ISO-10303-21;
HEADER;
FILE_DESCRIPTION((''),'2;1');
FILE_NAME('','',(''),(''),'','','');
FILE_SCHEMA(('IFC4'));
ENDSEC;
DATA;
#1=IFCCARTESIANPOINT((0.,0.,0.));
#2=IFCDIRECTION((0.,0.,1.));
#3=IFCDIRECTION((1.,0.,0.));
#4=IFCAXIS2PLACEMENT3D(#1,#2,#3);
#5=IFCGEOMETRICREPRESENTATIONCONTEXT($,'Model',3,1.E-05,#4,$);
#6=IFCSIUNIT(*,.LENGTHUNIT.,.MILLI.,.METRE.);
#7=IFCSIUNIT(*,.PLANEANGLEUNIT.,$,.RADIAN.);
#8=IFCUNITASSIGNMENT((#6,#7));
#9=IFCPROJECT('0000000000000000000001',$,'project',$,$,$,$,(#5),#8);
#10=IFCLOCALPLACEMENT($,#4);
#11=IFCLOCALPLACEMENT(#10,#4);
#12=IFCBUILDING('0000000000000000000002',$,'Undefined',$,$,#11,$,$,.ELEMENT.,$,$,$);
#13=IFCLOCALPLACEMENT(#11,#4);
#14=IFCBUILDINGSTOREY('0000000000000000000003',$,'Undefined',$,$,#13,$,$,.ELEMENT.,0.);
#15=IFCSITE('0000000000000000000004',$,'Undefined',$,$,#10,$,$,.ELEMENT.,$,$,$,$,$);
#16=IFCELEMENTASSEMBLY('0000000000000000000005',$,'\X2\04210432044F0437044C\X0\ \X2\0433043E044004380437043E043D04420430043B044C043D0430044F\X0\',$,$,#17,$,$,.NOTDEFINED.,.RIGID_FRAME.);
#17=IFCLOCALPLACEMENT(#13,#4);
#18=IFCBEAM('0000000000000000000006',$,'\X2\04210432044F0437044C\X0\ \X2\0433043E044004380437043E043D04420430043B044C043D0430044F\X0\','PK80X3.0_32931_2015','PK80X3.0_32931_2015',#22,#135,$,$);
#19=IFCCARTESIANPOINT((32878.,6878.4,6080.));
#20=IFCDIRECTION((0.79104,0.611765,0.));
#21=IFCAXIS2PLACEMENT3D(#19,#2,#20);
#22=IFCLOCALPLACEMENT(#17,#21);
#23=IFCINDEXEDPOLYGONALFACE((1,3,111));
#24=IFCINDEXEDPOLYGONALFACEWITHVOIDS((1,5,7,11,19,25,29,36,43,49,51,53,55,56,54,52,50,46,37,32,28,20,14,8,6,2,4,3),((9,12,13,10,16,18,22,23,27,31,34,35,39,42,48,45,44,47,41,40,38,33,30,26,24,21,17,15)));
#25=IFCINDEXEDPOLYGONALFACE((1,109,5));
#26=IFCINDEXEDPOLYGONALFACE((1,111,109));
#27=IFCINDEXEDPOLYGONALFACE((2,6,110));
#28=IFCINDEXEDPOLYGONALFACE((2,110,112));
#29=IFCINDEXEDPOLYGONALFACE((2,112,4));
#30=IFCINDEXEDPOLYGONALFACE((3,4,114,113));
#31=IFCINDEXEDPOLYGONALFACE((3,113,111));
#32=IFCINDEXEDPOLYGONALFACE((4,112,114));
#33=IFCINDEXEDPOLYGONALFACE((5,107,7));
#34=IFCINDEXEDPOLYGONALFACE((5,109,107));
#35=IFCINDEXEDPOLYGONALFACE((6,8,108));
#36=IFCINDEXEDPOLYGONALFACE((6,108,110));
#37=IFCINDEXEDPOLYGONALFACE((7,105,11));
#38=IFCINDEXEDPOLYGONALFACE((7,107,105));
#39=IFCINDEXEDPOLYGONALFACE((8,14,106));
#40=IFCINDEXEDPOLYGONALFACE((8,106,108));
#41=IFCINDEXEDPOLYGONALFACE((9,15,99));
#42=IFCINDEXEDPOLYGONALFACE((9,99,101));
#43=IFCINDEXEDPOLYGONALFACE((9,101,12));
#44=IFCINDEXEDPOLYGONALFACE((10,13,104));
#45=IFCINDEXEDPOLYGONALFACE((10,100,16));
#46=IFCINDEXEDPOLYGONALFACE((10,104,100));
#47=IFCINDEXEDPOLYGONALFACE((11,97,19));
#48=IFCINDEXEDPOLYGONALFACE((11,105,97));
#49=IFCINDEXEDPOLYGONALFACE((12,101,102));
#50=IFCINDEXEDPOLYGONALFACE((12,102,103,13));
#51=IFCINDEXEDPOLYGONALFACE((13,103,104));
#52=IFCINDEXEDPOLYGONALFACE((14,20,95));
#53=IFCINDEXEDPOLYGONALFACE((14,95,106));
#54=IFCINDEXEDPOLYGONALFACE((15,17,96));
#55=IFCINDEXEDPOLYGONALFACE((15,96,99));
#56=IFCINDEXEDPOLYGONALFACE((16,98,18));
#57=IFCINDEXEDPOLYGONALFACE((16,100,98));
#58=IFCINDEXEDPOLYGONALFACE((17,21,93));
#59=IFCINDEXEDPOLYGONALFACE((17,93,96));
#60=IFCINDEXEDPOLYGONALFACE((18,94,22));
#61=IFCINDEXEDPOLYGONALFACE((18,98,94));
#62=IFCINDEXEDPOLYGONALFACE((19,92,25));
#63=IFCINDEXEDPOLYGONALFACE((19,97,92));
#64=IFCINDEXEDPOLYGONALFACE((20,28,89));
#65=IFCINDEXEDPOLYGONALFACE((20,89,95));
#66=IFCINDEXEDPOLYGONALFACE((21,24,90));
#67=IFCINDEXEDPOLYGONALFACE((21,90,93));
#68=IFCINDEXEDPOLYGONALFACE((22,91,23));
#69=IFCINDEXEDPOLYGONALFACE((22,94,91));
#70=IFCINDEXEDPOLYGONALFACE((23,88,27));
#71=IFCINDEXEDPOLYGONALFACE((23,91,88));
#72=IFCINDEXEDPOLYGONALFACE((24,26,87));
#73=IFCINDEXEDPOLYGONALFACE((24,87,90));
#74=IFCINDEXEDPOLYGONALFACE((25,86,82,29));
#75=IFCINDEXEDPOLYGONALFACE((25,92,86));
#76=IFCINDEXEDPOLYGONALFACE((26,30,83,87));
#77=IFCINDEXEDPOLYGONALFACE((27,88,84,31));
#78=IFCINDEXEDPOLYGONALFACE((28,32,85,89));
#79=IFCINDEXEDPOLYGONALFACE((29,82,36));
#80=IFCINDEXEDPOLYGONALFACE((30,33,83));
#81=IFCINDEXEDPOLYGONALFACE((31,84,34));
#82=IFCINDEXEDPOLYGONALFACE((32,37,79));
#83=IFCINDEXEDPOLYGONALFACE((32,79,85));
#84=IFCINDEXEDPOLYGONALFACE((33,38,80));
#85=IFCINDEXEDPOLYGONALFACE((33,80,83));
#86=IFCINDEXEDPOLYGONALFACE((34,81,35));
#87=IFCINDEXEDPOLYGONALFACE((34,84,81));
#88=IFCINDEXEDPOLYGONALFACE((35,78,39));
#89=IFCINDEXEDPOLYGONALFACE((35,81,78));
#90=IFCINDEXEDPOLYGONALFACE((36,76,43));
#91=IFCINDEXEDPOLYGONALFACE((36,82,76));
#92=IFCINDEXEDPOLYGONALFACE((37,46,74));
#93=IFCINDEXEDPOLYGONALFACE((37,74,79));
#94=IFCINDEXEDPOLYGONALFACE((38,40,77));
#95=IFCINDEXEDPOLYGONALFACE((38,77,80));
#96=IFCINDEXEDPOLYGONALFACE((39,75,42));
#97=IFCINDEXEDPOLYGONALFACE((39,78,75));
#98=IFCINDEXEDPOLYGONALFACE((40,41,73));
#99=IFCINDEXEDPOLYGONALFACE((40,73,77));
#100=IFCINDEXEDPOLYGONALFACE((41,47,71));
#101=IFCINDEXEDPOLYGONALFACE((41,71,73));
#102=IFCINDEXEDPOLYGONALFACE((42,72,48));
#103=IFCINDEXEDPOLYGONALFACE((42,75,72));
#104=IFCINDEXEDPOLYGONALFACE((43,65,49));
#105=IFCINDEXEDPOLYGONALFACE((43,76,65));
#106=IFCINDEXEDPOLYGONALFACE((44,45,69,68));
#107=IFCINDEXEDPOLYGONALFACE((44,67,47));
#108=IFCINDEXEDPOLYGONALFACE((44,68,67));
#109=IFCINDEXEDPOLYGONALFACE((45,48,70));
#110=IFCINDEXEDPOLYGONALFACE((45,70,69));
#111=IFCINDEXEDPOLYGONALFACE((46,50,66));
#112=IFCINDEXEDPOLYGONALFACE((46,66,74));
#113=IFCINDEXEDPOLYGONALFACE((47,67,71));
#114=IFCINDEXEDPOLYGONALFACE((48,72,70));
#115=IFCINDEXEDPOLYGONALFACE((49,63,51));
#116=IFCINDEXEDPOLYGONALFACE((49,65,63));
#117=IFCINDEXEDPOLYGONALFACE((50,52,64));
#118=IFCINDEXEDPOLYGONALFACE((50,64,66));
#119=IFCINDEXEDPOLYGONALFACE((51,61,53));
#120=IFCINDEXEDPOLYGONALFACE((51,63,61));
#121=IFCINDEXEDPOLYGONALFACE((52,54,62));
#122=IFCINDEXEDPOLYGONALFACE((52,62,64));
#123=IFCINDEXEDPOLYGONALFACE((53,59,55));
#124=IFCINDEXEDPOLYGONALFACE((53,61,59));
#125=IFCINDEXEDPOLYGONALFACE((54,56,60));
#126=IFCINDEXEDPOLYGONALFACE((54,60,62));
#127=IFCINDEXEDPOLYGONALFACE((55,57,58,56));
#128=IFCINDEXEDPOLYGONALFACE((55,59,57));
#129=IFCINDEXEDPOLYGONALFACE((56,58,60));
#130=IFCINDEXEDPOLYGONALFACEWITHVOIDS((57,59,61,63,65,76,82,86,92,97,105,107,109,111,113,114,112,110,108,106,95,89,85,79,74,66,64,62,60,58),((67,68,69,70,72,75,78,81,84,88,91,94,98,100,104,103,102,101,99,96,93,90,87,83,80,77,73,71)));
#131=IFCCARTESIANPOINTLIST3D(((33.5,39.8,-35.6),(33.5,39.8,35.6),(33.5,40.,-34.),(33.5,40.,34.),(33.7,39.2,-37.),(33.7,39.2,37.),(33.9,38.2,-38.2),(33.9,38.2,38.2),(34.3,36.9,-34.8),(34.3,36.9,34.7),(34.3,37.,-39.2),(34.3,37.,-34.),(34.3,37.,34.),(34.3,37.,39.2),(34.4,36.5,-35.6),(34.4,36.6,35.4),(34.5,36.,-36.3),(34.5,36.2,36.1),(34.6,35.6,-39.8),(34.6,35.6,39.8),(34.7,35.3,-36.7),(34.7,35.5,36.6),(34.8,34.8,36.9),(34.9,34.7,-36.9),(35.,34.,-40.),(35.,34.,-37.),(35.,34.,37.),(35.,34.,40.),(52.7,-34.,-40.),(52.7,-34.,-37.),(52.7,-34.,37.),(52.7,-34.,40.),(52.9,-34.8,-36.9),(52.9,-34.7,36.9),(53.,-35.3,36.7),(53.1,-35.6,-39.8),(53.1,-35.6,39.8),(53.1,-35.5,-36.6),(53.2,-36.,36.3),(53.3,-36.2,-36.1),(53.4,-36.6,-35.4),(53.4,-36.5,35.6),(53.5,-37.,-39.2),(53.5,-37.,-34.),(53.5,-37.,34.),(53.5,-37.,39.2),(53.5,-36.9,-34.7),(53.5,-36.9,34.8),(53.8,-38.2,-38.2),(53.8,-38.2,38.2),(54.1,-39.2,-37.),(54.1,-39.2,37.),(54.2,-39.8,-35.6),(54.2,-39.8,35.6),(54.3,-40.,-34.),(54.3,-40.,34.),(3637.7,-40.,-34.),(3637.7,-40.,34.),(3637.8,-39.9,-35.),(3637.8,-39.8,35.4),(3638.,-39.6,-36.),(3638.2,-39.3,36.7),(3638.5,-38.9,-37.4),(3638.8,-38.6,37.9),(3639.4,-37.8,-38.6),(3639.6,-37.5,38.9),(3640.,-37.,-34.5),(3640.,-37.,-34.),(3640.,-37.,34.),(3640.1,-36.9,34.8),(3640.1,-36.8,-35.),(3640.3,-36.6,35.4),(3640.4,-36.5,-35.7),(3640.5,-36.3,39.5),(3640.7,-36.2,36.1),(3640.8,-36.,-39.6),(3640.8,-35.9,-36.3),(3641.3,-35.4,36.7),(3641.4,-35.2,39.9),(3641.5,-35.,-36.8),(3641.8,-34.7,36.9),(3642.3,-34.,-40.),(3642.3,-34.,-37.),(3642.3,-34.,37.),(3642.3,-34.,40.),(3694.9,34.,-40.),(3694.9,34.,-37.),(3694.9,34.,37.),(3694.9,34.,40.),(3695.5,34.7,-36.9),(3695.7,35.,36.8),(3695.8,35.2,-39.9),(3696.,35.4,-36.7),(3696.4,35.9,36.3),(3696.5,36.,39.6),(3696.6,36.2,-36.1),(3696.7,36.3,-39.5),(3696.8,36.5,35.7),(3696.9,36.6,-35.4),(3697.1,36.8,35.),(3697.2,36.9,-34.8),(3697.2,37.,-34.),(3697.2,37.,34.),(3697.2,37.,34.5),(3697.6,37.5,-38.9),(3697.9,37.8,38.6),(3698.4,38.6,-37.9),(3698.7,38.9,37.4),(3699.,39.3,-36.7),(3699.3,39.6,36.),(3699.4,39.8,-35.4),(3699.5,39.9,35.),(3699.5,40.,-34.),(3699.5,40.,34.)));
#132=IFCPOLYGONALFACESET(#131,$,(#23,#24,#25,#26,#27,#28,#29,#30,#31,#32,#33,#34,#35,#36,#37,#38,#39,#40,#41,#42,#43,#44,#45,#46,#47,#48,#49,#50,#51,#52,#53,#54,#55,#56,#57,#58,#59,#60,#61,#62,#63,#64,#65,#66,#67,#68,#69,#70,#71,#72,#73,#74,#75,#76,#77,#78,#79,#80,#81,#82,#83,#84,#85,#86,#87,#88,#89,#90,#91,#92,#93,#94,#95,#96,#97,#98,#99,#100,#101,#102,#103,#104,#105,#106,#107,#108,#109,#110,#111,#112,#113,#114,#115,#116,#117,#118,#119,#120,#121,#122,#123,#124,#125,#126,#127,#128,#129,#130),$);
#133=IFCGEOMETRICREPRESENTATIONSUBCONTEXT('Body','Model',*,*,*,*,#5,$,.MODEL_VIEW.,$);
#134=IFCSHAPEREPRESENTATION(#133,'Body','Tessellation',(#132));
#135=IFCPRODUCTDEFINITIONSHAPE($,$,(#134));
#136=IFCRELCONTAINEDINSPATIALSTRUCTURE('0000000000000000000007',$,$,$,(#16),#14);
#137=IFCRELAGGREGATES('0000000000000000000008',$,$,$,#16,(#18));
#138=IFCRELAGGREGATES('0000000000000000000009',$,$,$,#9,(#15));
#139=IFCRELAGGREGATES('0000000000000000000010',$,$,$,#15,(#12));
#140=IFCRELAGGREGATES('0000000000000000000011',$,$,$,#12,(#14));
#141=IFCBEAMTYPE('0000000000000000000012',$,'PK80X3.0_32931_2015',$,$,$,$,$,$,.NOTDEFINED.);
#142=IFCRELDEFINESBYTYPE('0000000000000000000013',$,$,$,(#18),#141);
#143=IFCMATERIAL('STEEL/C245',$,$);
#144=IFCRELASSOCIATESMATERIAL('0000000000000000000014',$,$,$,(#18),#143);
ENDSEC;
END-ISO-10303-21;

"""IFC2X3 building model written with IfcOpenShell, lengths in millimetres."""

from ifc_helpers import new_model, si_unit, frame, origin_with_axes, origin_2d_with_axis, place, context, subcontext, project, spatial, hollow_rectangle, extrude, clip, halfspace, material, type_object, element, aggregate, save


model = new_model("IFC2X3")

# Units and contexts
model_context = context("Model", 3, precision=1e-05, world=origin_with_axes())
body_context = subcontext(model_context, "Body", "Model", "MODEL_VIEW")
ifc_project = project(units=[si_unit("LENGTHUNIT", "METRE", prefix="MILLI"), si_unit("PLANEANGLEUNIT", "RADIAN")], contexts=[model_context])

# Site, building, storey
site_placement = place(None, origin_with_axes())
site = spatial("IfcSite", under=ifc_project, at=site_placement, Name="Undefined", CompositionType="ELEMENT")
building_placement = place(site_placement, origin_with_axes())
building = spatial("IfcBuilding", under=site, at=building_placement, Name="Undefined", CompositionType="ELEMENT")
storey_placement = place(building_placement, origin_with_axes())
storey = spatial("IfcBuildingStorey", under=building, at=storey_placement, Name="Undefined", CompositionType="ELEMENT", Elevation=0.0)

# Shared definitions
ifc_material = material(Name="STEEL/C245")

# Element assembly, beam
assembly_1_placement = place(storey_placement, origin_with_axes())
assembly_1 = element("IfcElementAssembly", 1, at=assembly_1_placement, inside=storey, Name="Связь горизонтальная", AssemblyPlace="NOTDEFINED", PredefinedType="RIGID_FRAME")
beam_type_1 = type_object("IfcBeamType", Name="PK80X3.0_32931_2015", PredefinedType="NOTDEFINED")
beam_1_placement = place(assembly_1_placement, frame((32878.0, 6878.4, 6080.0), z_axis=(0.0, 0.0, 1.0), x_axis=(0.79104, 0.611765, 0.0)))
beam_1 = element("IfcBeam", 2, at=beam_1_placement, type_object=beam_type_1, material=ifc_material, Name="Связь горизонтальная", Description="PK80X3.0_32931_2015", ObjectType="PK80X3.0_32931_2015", context=body_context, shape_type="Clipping", body=[
    clip(clip(extrude(hollow_rectangle(XDim=80.0, YDim=80.0, WallThickness=3.0, InnerFilletRadius=3.0, OuterFilletRadius=6.0, at=origin_2d_with_axis()), frame((3741.6, 0.0, 0.0), z_axis=(-1.0, 0.0, 0.0), x_axis=(0.0, -1.0, 0.0)), (0.0, 0.0, 1.0), 3770.7), halfspace(frame((3583.9, -109.6, 40.0), z_axis=(-0.79104, 0.611765, 0.0), x_axis=(0.0, 0.0, 1.0)), True)), halfspace(frame((25.2, 72.0, 40.0), z_axis=(-0.96786, -0.251488, 0.0), x_axis=(0.0, 0.0, 1.0)), False)),
])
aggregate(assembly_1, [beam_1])

save(model, "model.ifc")
